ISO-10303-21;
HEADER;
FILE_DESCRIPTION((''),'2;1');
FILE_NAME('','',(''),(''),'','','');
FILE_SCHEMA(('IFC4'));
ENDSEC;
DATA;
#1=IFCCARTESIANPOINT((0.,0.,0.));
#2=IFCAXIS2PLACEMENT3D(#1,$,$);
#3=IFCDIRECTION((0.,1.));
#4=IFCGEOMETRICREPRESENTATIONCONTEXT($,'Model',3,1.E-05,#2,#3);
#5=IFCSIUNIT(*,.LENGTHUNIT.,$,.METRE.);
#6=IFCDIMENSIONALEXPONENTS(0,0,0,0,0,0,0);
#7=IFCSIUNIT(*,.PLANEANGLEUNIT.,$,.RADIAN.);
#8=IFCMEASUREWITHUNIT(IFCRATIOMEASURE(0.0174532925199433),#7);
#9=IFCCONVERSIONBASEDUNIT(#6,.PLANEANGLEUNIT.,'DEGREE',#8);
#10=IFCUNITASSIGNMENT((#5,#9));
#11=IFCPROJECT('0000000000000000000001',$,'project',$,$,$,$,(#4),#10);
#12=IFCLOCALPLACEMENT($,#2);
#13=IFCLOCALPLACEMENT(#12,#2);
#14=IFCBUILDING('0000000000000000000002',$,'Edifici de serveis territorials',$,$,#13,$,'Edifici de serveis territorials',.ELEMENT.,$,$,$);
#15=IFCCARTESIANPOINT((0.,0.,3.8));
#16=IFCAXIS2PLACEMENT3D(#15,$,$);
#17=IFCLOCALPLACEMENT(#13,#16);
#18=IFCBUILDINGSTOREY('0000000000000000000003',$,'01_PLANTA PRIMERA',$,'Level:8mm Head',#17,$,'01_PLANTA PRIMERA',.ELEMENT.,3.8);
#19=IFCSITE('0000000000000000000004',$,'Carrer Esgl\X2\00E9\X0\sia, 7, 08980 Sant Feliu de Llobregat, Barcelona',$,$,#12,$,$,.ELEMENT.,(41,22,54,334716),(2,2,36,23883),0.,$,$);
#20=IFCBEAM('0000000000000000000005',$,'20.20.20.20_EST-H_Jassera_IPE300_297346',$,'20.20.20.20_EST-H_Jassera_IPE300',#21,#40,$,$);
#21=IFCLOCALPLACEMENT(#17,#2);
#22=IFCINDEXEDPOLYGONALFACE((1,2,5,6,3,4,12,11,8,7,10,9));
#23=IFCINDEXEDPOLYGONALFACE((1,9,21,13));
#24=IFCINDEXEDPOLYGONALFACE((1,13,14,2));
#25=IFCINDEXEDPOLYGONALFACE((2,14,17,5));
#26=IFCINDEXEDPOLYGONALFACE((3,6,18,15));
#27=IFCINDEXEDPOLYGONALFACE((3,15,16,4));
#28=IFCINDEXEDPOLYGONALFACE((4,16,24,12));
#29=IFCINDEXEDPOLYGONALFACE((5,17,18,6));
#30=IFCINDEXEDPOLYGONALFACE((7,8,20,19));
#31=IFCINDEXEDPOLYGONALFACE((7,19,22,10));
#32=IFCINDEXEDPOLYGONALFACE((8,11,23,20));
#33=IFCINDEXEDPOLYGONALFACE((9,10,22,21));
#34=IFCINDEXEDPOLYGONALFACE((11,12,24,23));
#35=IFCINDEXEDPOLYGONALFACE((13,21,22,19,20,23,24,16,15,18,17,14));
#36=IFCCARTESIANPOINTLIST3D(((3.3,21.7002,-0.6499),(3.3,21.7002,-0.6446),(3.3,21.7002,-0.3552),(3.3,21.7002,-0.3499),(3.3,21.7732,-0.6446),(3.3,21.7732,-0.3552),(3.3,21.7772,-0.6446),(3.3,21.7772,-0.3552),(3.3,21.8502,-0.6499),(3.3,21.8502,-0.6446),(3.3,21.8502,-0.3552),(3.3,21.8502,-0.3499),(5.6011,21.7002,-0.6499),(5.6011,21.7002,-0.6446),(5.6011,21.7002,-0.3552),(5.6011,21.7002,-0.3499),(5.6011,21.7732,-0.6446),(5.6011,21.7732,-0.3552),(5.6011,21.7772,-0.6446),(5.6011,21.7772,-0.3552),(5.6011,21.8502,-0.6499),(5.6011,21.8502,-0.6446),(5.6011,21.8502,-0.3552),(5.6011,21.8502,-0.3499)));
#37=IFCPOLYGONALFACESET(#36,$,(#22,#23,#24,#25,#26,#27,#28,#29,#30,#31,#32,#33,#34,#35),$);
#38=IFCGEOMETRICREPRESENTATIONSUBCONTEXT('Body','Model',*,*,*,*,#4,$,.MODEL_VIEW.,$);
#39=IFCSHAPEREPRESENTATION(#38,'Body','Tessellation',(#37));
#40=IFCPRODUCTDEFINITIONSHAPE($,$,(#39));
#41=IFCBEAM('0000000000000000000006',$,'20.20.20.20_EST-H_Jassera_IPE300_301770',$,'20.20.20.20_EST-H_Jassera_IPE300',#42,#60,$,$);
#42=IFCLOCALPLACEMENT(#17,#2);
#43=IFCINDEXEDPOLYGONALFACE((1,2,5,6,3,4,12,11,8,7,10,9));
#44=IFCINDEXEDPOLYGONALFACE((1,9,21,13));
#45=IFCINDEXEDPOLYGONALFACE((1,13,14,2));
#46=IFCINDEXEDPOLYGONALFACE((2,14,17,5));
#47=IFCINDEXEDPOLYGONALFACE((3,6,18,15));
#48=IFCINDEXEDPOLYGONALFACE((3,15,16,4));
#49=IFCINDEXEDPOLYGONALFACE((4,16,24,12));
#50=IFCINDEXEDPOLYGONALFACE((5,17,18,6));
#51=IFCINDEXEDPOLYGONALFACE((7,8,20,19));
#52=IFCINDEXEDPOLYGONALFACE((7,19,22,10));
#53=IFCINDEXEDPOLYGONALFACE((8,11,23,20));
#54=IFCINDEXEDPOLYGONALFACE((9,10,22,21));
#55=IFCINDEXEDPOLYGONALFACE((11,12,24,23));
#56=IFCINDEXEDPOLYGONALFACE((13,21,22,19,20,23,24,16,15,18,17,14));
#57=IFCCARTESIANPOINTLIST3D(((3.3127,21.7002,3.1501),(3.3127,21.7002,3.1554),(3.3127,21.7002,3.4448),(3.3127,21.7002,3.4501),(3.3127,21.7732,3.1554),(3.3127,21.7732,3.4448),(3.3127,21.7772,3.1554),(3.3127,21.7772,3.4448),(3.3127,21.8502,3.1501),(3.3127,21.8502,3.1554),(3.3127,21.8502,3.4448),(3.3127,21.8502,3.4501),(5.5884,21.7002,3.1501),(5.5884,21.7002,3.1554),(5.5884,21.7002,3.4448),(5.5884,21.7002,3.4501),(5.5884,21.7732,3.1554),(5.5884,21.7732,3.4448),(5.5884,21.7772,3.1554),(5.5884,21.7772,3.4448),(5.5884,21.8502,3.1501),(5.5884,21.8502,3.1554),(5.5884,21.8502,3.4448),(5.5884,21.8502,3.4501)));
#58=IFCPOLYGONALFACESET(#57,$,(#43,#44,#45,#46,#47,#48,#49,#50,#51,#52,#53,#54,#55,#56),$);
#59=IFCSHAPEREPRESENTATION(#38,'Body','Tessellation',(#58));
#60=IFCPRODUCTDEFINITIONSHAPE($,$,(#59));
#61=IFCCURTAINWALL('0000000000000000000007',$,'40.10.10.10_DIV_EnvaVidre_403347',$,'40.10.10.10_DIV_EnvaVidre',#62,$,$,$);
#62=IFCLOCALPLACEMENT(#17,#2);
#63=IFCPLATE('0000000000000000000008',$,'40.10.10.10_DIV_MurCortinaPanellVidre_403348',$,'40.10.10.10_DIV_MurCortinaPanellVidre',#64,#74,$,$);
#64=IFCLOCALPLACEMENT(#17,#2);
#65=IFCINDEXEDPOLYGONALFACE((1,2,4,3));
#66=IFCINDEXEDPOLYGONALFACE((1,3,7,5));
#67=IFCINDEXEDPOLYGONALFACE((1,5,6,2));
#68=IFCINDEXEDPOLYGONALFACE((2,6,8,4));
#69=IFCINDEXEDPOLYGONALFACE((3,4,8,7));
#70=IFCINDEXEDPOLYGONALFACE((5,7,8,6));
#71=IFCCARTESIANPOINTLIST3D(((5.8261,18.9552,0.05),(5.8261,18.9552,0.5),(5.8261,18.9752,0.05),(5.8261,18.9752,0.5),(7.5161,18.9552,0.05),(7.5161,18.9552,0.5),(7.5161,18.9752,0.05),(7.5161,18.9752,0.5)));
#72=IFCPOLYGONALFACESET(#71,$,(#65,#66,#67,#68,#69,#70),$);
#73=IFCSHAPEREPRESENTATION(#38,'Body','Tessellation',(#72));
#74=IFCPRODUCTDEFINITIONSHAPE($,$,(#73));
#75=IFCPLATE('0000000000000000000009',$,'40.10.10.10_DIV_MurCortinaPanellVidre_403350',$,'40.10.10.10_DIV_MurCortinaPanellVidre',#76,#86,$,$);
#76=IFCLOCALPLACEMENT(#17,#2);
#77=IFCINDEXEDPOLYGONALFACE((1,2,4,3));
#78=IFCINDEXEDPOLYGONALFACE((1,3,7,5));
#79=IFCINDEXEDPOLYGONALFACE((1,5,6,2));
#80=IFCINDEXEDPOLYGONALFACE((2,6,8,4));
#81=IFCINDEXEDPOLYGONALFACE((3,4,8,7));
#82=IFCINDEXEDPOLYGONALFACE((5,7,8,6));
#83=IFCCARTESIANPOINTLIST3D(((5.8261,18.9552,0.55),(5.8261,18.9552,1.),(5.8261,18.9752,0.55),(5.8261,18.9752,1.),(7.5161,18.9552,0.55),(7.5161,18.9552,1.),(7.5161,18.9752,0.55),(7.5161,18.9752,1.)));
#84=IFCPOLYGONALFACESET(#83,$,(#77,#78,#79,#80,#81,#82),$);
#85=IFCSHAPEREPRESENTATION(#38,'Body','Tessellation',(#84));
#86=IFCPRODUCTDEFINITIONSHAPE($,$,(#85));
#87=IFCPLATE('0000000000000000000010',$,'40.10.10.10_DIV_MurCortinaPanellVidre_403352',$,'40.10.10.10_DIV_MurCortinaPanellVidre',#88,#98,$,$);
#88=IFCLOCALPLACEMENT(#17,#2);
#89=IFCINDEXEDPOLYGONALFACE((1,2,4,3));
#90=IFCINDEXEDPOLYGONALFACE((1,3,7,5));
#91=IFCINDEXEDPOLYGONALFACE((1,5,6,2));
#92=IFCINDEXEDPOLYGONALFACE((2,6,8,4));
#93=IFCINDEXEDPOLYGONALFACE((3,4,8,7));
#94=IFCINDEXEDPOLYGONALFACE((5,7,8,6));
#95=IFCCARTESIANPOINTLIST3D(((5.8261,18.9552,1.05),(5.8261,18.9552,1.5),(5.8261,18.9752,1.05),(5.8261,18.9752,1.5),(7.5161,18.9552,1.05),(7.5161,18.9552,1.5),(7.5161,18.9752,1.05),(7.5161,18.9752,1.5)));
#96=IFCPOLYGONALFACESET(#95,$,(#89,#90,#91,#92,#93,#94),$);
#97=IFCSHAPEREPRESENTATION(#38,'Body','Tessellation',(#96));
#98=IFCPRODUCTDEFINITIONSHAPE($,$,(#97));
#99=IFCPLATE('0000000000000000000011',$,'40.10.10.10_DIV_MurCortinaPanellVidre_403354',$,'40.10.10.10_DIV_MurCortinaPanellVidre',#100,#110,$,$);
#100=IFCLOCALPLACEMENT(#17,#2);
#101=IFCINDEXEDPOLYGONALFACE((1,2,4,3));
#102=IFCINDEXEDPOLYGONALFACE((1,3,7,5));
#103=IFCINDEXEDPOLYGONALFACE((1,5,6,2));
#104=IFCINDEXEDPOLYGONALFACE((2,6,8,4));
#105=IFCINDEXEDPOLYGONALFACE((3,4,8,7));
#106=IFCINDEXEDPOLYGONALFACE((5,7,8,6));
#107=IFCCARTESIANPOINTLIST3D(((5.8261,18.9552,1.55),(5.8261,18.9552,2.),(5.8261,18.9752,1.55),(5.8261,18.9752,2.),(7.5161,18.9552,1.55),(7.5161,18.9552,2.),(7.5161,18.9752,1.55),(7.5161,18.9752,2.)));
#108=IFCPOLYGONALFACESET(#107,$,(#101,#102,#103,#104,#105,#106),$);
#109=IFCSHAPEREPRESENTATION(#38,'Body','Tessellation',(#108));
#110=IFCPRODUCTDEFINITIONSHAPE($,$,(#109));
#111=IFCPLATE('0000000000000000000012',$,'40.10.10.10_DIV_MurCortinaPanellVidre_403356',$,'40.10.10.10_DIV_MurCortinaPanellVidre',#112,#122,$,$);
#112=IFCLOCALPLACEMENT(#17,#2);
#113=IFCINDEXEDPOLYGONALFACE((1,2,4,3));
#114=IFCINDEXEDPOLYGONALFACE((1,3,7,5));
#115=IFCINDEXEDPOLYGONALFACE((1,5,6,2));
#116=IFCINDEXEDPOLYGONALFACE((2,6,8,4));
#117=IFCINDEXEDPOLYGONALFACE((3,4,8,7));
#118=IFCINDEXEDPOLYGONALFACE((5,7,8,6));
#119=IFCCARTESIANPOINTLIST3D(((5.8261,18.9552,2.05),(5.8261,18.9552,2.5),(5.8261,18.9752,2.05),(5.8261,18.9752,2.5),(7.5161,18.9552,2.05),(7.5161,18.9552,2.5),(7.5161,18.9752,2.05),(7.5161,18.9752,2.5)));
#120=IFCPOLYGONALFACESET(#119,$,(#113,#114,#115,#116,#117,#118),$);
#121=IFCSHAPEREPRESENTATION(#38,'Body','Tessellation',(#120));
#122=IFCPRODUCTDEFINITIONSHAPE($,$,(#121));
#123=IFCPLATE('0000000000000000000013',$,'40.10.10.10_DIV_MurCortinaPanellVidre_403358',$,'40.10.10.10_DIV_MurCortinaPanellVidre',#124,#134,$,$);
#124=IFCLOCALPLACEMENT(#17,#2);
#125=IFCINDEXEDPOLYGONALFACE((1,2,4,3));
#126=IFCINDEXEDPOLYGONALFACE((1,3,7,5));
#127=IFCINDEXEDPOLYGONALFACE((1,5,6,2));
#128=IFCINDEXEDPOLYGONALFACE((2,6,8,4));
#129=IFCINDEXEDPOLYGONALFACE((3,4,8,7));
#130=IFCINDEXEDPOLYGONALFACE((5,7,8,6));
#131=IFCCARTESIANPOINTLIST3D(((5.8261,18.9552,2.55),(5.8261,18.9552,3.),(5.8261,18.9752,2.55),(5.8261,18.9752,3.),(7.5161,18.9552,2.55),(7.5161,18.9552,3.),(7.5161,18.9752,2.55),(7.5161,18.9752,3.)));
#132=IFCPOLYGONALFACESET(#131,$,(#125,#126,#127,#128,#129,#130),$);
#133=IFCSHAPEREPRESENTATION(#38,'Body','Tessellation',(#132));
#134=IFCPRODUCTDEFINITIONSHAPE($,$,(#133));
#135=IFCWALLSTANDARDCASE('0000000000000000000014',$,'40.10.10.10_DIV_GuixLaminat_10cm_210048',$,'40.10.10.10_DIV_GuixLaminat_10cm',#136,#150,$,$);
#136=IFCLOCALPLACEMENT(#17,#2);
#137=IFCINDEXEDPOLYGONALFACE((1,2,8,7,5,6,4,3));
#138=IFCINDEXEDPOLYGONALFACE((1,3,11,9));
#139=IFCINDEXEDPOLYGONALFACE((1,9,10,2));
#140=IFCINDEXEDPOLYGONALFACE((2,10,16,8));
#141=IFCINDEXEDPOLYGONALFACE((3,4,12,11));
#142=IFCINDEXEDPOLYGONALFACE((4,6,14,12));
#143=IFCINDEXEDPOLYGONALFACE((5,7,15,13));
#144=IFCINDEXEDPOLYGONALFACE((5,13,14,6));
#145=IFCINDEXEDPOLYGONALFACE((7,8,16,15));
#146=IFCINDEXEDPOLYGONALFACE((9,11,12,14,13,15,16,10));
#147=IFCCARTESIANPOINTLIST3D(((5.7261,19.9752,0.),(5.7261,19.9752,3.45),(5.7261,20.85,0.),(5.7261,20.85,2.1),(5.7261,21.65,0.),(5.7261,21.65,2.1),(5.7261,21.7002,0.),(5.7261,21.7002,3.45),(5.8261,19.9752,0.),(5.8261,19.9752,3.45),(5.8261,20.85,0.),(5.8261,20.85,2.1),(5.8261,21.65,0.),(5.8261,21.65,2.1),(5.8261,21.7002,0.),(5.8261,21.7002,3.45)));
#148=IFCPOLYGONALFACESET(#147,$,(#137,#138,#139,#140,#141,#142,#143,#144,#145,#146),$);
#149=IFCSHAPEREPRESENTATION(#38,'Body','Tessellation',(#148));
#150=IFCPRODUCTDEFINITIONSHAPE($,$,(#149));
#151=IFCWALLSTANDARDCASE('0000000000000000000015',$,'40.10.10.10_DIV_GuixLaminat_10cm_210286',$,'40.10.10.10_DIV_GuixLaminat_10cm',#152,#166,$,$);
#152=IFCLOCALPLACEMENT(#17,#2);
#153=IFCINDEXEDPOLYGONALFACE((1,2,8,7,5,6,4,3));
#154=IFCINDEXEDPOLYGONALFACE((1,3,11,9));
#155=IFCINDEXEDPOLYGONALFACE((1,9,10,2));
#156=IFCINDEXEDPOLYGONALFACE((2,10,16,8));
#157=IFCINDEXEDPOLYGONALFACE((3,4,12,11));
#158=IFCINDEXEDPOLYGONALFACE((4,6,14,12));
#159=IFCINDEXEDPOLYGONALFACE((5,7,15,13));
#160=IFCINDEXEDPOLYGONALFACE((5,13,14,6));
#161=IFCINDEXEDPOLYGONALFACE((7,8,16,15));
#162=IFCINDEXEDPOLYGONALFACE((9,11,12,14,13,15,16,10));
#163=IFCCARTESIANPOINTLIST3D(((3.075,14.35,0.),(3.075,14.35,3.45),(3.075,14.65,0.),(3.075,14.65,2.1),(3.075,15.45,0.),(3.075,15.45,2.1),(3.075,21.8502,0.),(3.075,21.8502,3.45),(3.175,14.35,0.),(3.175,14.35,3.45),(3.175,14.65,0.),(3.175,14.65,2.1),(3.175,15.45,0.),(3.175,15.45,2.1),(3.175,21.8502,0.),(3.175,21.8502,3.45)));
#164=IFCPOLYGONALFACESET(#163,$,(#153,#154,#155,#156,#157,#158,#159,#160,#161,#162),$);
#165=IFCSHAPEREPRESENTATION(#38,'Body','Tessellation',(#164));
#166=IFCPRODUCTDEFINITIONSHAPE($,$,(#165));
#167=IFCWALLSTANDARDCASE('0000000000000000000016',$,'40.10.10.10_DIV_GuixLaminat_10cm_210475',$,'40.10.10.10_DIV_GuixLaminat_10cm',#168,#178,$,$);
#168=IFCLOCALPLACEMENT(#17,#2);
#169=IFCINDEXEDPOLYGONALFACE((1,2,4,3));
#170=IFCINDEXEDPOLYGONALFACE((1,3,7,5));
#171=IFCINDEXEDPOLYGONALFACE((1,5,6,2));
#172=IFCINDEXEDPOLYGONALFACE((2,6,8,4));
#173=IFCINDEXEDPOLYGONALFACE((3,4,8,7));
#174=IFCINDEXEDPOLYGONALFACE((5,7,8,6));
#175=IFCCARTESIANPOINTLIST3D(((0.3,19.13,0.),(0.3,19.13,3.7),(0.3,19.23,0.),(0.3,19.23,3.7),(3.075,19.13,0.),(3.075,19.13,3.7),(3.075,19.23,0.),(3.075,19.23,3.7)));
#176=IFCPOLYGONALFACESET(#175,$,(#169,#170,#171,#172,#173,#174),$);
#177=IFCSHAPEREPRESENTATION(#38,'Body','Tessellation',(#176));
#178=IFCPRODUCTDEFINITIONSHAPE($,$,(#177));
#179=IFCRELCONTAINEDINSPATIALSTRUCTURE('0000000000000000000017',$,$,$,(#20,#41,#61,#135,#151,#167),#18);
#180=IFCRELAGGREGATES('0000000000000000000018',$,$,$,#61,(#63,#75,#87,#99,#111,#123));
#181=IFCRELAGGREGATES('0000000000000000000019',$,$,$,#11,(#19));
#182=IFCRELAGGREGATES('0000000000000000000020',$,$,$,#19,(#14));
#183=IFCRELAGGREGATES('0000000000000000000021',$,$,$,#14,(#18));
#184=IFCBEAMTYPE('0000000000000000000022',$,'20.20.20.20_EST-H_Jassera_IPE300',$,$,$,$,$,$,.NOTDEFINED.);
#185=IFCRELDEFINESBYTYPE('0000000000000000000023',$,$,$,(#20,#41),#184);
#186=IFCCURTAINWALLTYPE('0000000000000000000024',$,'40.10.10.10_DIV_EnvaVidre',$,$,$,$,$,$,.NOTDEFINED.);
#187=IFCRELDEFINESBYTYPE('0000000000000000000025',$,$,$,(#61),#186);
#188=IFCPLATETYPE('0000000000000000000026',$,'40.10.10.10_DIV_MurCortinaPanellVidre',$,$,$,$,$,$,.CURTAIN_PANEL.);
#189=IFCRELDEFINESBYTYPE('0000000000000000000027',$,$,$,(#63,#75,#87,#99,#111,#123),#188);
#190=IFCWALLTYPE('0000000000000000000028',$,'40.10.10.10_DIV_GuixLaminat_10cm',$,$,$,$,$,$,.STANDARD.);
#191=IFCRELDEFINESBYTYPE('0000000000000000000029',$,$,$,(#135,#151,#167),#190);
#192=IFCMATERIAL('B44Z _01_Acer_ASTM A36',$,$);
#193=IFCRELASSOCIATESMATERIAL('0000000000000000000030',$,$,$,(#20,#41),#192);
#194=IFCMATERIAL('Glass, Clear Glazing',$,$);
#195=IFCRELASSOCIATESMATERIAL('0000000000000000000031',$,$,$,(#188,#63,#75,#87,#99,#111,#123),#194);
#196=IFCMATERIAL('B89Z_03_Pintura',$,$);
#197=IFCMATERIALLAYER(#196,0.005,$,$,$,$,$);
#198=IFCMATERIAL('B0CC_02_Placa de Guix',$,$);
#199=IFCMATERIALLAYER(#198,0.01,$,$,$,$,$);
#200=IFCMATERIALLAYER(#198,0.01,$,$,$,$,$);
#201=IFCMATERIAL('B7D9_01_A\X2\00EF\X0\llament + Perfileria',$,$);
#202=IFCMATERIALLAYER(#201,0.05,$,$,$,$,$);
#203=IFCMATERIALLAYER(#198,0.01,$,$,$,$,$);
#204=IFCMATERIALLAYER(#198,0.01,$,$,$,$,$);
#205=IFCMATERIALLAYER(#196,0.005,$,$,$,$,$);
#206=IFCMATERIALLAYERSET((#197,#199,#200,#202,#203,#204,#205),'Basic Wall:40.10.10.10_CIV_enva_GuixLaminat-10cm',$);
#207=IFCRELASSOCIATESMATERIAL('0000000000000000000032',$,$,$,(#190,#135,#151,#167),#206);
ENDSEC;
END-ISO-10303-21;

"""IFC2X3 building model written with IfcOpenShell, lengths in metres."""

from ifc_helpers import new_model, entity, si_unit, converted_unit, direction, frame, frame_2d, origin, place, context, subcontext, project, spatial, polyline, rectangle, i_section, extrude, clip, bounded_halfspace, source, transform, mapped, material, layer, layer_set, layer_usage, type_object, type_shapes, element, aggregate, save


model = new_model("IFC2X3")

# Units and contexts
model_context = context("Model", 3, precision=1e-05, world=origin(), true_north=direction((0.0, 1.0)))
body_context = subcontext(model_context, "Body", "Model", "MODEL_VIEW")
ifc_project = project(units=[si_unit("LENGTHUNIT", "METRE"), converted_unit("PLANEANGLEUNIT", "DEGREE", entity("IfcRatioMeasure", 0.0174532925199433), si_unit("PLANEANGLEUNIT", "RADIAN"), dimensions=[0, 0, 0, 0, 0, 0, 0])], contexts=[model_context])

# Site, building, storey
site_placement = place(None, origin())
site = spatial("IfcSite", under=ifc_project, at=site_placement, Name="Carrer Església, 7, 08980 Sant Feliu de Llobregat, Barcelona", CompositionType="ELEMENT", RefLatitude=(41, 22, 54, 334716), RefLongitude=(2, 2, 36, 23883), RefElevation=0.0)
building_placement = place(site_placement, origin())
building = spatial("IfcBuilding", under=site, at=building_placement, Name="Edifici de serveis territorials", LongName="Edifici de serveis territorials", CompositionType="ELEMENT")
storey_placement = place(building_placement, frame((0.0, 0.0, 3.8)))
storey = spatial("IfcBuildingStorey", under=building, at=storey_placement, Name="01_PLANTA PRIMERA", ObjectType="Level:8mm Head", LongName="01_PLANTA PRIMERA", CompositionType="ELEMENT", Elevation=3.8)

# Shared definitions
ifc_material_1 = material(Name="B44Z _01_Acer_ASTM A36")

# Beams
beam_type = type_object("IfcBeamType", Name="20.20.20.20_EST-H_Jassera_IPE300", PredefinedType="NOTDEFINED")
beam_1_placement = place(storey_placement, frame((3.3, 21.7752, 0.0)))
element("IfcBeam", 1, at=beam_1_placement, inside=storey, type_object=beam_type, material=ifc_material_1, Name="20.20.20.20_EST-H_Jassera_IPE300_297346", ObjectType="20.20.20.20_EST-H_Jassera_IPE300", context=body_context, shape_type="SweptSolid", body=[
    extrude(i_section(OverallWidth=0.15, OverallDepth=0.3, WebThickness=0.0041, FlangeThickness=0.0053, at=frame_2d((0.0, 0.0), x_axis=(0.0, 1.0))), frame((0.0, 0.0, -0.4999), z_axis=(1.0, 0.0, 0.0), x_axis=(0.0, 0.0, -1.0)), (0.0, 0.0, 1.0), 2.3011),
])
beam_2_placement = place(storey_placement, frame((3.3, 21.7752, 0.0)))
element("IfcBeam", 2, at=beam_2_placement, inside=storey, type_object=beam_type, material=ifc_material_1, Name="20.20.20.20_EST-H_Jassera_IPE300_301770", ObjectType="20.20.20.20_EST-H_Jassera_IPE300", context=body_context, shape_type="SweptSolid", body=[
    extrude(i_section(OverallWidth=0.15, OverallDepth=0.3, WebThickness=0.0041, FlangeThickness=0.0053, at=frame_2d((0.0, 0.0), x_axis=(0.0, 1.0))), frame((0.0127, 0.0, 3.3001), z_axis=(1.0, 0.0, 0.0), x_axis=(0.0, 0.0, -1.0)), (0.0, 0.0, 1.0), 2.2757),
])

# Curtain wall, plates
curtain_wall_type = type_object("IfcCurtainWallType", Name="40.10.10.10_DIV_EnvaVidre", PredefinedType="NOTDEFINED")
curtain_wall_placement = place(storey_placement, frame((0.0, 0.0, -3.8)))
curtain_wall = element("IfcCurtainWall", 3, at=curtain_wall_placement, inside=storey, type_object=curtain_wall_type, Name="40.10.10.10_DIV_EnvaVidre_403347", ObjectType="40.10.10.10_DIV_EnvaVidre")
ifc_material_2 = material(Name="Glass, Clear Glazing")
plate_type = type_object("IfcPlateType", Name="40.10.10.10_DIV_MurCortinaPanellVidre", PredefinedType="CURTAIN_PANEL", material=ifc_material_2)
shared_shape_1 = source(origin(), body_context, "Body", "SweptSolid", [
    extrude(rectangle(XDim=0.02, YDim=1.69, at=frame_2d((0.0, 0.0), x_axis=(1.0, 0.0))), frame((0.845, 0.01, 0.0), z_axis=(0.0, 0.0, 1.0), x_axis=(0.0, 1.0, 0.0)), (0.0, 0.0, 1.0), 0.45),
])
type_shapes(plate_type, [shared_shape_1])
plate_1_placement = place(curtain_wall_placement, frame((5.8261, 18.9552, 3.85)))
plate_1 = element("IfcPlate", 4, at=plate_1_placement, type_object=plate_type, material=ifc_material_2, Name="40.10.10.10_DIV_MurCortinaPanellVidre_403348", ObjectType="40.10.10.10_DIV_MurCortinaPanellVidre", context=body_context, shape_type="MappedRepresentation", body=[
    mapped(shared_shape_1, transform((0.0, 0.0, 0.0), scale=1.0)),
])
plate_2_placement = place(curtain_wall_placement, frame((5.8261, 18.9552, 4.35)))
plate_2 = element("IfcPlate", 5, at=plate_2_placement, type_object=plate_type, material=ifc_material_2, Name="40.10.10.10_DIV_MurCortinaPanellVidre_403350", ObjectType="40.10.10.10_DIV_MurCortinaPanellVidre", context=body_context, shape_type="MappedRepresentation", body=[
    mapped(shared_shape_1, transform((0.0, 0.0, 0.0), scale=1.0)),
])
plate_3_placement = place(curtain_wall_placement, frame((5.8261, 18.9552, 4.85)))
plate_3 = element("IfcPlate", 6, at=plate_3_placement, type_object=plate_type, material=ifc_material_2, Name="40.10.10.10_DIV_MurCortinaPanellVidre_403352", ObjectType="40.10.10.10_DIV_MurCortinaPanellVidre", context=body_context, shape_type="MappedRepresentation", body=[
    mapped(shared_shape_1, transform((0.0, 0.0, 0.0), scale=1.0)),
])
plate_4_placement = place(curtain_wall_placement, frame((5.8261, 18.9552, 5.35)))
plate_4 = element("IfcPlate", 7, at=plate_4_placement, type_object=plate_type, material=ifc_material_2, Name="40.10.10.10_DIV_MurCortinaPanellVidre_403354", ObjectType="40.10.10.10_DIV_MurCortinaPanellVidre", context=body_context, shape_type="MappedRepresentation", body=[
    mapped(shared_shape_1, transform((0.0, 0.0, 0.0), scale=1.0)),
])
plate_5_placement = place(curtain_wall_placement, frame((5.8261, 18.9552, 5.85)))
plate_5 = element("IfcPlate", 8, at=plate_5_placement, type_object=plate_type, material=ifc_material_2, Name="40.10.10.10_DIV_MurCortinaPanellVidre_403356", ObjectType="40.10.10.10_DIV_MurCortinaPanellVidre", context=body_context, shape_type="MappedRepresentation", body=[
    mapped(shared_shape_1, transform((0.0, 0.0, 0.0), scale=1.0)),
])
plate_6_placement = place(curtain_wall_placement, frame((5.8261, 18.9552, 6.35)))
plate_6 = element("IfcPlate", 9, at=plate_6_placement, type_object=plate_type, material=ifc_material_2, Name="40.10.10.10_DIV_MurCortinaPanellVidre_403358", ObjectType="40.10.10.10_DIV_MurCortinaPanellVidre", context=body_context, shape_type="MappedRepresentation", body=[
    mapped(shared_shape_1, transform((0.0, 0.0, 0.0), scale=1.0)),
])
aggregate(curtain_wall, [plate_1, plate_2, plate_3, plate_4, plate_5, plate_6])

# Wall, opening
ifc_material_3 = material(Name="B89Z_03_Pintura")
ifc_layer_1 = layer(ifc_material_3, 0.005)
ifc_material_4 = material(Name="B0CC_02_Placa de Guix")
ifc_layer_2 = layer(ifc_material_4, 0.01)
ifc_layer_3 = layer(ifc_material_4, 0.01)
ifc_material_5 = material(Name="B7D9_01_Aïllament + Perfileria")
ifc_layer_4 = layer(ifc_material_5, 0.05)
ifc_layer_5 = layer(ifc_material_4, 0.01)
ifc_layer_6 = layer(ifc_material_4, 0.01)
ifc_layer_7 = layer(ifc_material_3, 0.005)
ifc_layer_set_1 = layer_set([ifc_layer_1, ifc_layer_2, ifc_layer_3, ifc_layer_4, ifc_layer_5, ifc_layer_6, ifc_layer_7], Name="Basic Wall:40.10.10.10_CIV_enva_GuixLaminat-10cm")
ifc_layer_usage_1 = layer_usage(ifc_layer_set_1, "AXIS2", "NEGATIVE", 0.05)
wall_type_1 = type_object("IfcWallType", Name="40.10.10.10_DIV_GuixLaminat_10cm", PredefinedType="STANDARD", material=ifc_layer_set_1)
wall_1_placement = place(storey_placement, frame((5.7761, 21.7002, 0.0), z_axis=(0.0, 0.0, 1.0), x_axis=(0.0, -1.0, 0.0)))
wall_1 = element("IfcWallStandardCase", 10, at=wall_1_placement, inside=storey, type_object=wall_type_1, material=ifc_layer_usage_1, Name="40.10.10.10_DIV_GuixLaminat_10cm_210048", ObjectType="40.10.10.10_DIV_GuixLaminat_10cm", context=body_context, shape_type="Clipping", body=[
    clip(extrude(rectangle(XDim=1.725, YDim=0.1, at=frame_2d((0.8625, 0.0), x_axis=(-1.0, 0.0))), origin(), (0.0, 0.0, 1.0), 3.45), bounded_halfspace(frame((0.0, -0.05, 3.45), z_axis=(0.0, 0.0, -1.0), x_axis=(0.999675, 0.025497, 0.0)), True, frame((0.0, -0.05, 3.45)), polyline([(0.0, 0.0), (1.725, 0.0), (1.725, 0.025), (1.725, 0.1), (0.0, 0.1), (0.0, 0.025), (0.0, 0.0)]))),
])
opening_1_placement = place(wall_1_placement, frame((0.8502, 0.05, 0.0)))
element("IfcOpeningElement", 11, at=opening_1_placement, cuts=wall_1, ObjectType="Opening", context=body_context, shape_type="SweptSolid", body=[
    extrude(rectangle(XDim=2.1, YDim=0.8, at=frame_2d((1.05, 0.4), x_axis=(1.0, 0.0))), frame((0.0, 0.0, 0.0), z_axis=(0.0, -1.0, 0.0), x_axis=(0.0, 0.0, 1.0)), (0.0, 0.0, 1.0), 0.1),
])

# Wall, openings
ifc_layer_usage_2 = layer_usage(ifc_layer_set_1, "AXIS2", "NEGATIVE", 0.05)
wall_2_placement = place(storey_placement, frame((3.125, 21.8502, 0.0), z_axis=(0.0, 0.0, 1.0), x_axis=(0.0, -1.0, 0.0)))
wall_2 = element("IfcWallStandardCase", 12, at=wall_2_placement, inside=storey, type_object=wall_type_1, material=ifc_layer_usage_2, Name="40.10.10.10_DIV_GuixLaminat_10cm_210286", ObjectType="40.10.10.10_DIV_GuixLaminat_10cm", context=body_context, shape_type="Clipping", body=[
    clip(extrude(rectangle(XDim=7.5002, YDim=0.1, at=frame_2d((3.7501, 0.0), x_axis=(-1.0, 0.0))), origin(), (0.0, 0.0, 1.0), 3.45), bounded_halfspace(frame((0.0, -0.05, 3.45), z_axis=(0.0, 0.0, -1.0), x_axis=(0.999675, 0.025497, 0.0)), True, frame((0.0, -0.05, 3.45)), polyline([(0.0, 0.0), (7.5002, 0.0), (7.5002, 0.1), (7.4002, 0.1), (0.15, 0.1), (0.0, 0.1), (0.0, 0.0)]))),
])
opening_2_placement = place(wall_2_placement, frame((7.2002, 0.05, 0.0)))
element("IfcOpeningElement", 13, at=opening_2_placement, cuts=wall_2, ObjectType="Opening", context=body_context, shape_type="SweptSolid", body=[
    extrude(rectangle(XDim=2.1, YDim=0.8, at=frame_2d((1.05, 0.4), x_axis=(1.0, 0.0))), frame((0.0, 0.0, 0.0), z_axis=(0.0, -1.0, 0.0), x_axis=(0.0, 0.0, 1.0)), (0.0, 0.0, 1.0), 0.1),
])
opening_3_placement = place(wall_2_placement, frame((1.0002, 0.15, 0.0)))
element("IfcOpeningElement", 14, at=opening_3_placement, cuts=wall_2, ObjectType="Opening", context=body_context, shape_type="SweptSolid", body=[
    extrude(rectangle(XDim=2.1, YDim=0.8, at=frame_2d((1.05, 0.4), x_axis=(1.0, 0.0))), frame((0.0, 0.0, 0.0), z_axis=(0.0, -1.0, 0.0), x_axis=(0.0, 0.0, 1.0)), (0.0, 0.0, 1.0), 0.1),
])

# Wall
ifc_layer_usage_3 = layer_usage(ifc_layer_set_1, "AXIS2", "NEGATIVE", 0.05)
wall_3_placement = place(storey_placement, frame((3.075, 19.18, 0.0), z_axis=(0.0, 0.0, 1.0), x_axis=(-1.0, 0.0, 0.0)))
element("IfcWallStandardCase", 15, at=wall_3_placement, inside=storey, type_object=wall_type_1, material=ifc_layer_usage_3, Name="40.10.10.10_DIV_GuixLaminat_10cm_210475", ObjectType="40.10.10.10_DIV_GuixLaminat_10cm", context=body_context, shape_type="Clipping", body=[
    clip(extrude(rectangle(XDim=2.775, YDim=0.1, at=frame_2d((1.3875, 0.0), x_axis=(-1.0, 0.0))), origin(), (0.0, 0.0, 1.0), 3.7), bounded_halfspace(frame((0.0, -0.05, 3.7), z_axis=(0.0, 0.0, -1.0), x_axis=(0.0, -1.0, 0.0)), True, frame((0.0, -0.05, 3.7)), polyline([(0.0, 0.0), (2.775, 0.0), (2.775, 0.1), (0.0, 0.1), (0.0, 0.0)]))),
])

save(model, "model.ifc")
